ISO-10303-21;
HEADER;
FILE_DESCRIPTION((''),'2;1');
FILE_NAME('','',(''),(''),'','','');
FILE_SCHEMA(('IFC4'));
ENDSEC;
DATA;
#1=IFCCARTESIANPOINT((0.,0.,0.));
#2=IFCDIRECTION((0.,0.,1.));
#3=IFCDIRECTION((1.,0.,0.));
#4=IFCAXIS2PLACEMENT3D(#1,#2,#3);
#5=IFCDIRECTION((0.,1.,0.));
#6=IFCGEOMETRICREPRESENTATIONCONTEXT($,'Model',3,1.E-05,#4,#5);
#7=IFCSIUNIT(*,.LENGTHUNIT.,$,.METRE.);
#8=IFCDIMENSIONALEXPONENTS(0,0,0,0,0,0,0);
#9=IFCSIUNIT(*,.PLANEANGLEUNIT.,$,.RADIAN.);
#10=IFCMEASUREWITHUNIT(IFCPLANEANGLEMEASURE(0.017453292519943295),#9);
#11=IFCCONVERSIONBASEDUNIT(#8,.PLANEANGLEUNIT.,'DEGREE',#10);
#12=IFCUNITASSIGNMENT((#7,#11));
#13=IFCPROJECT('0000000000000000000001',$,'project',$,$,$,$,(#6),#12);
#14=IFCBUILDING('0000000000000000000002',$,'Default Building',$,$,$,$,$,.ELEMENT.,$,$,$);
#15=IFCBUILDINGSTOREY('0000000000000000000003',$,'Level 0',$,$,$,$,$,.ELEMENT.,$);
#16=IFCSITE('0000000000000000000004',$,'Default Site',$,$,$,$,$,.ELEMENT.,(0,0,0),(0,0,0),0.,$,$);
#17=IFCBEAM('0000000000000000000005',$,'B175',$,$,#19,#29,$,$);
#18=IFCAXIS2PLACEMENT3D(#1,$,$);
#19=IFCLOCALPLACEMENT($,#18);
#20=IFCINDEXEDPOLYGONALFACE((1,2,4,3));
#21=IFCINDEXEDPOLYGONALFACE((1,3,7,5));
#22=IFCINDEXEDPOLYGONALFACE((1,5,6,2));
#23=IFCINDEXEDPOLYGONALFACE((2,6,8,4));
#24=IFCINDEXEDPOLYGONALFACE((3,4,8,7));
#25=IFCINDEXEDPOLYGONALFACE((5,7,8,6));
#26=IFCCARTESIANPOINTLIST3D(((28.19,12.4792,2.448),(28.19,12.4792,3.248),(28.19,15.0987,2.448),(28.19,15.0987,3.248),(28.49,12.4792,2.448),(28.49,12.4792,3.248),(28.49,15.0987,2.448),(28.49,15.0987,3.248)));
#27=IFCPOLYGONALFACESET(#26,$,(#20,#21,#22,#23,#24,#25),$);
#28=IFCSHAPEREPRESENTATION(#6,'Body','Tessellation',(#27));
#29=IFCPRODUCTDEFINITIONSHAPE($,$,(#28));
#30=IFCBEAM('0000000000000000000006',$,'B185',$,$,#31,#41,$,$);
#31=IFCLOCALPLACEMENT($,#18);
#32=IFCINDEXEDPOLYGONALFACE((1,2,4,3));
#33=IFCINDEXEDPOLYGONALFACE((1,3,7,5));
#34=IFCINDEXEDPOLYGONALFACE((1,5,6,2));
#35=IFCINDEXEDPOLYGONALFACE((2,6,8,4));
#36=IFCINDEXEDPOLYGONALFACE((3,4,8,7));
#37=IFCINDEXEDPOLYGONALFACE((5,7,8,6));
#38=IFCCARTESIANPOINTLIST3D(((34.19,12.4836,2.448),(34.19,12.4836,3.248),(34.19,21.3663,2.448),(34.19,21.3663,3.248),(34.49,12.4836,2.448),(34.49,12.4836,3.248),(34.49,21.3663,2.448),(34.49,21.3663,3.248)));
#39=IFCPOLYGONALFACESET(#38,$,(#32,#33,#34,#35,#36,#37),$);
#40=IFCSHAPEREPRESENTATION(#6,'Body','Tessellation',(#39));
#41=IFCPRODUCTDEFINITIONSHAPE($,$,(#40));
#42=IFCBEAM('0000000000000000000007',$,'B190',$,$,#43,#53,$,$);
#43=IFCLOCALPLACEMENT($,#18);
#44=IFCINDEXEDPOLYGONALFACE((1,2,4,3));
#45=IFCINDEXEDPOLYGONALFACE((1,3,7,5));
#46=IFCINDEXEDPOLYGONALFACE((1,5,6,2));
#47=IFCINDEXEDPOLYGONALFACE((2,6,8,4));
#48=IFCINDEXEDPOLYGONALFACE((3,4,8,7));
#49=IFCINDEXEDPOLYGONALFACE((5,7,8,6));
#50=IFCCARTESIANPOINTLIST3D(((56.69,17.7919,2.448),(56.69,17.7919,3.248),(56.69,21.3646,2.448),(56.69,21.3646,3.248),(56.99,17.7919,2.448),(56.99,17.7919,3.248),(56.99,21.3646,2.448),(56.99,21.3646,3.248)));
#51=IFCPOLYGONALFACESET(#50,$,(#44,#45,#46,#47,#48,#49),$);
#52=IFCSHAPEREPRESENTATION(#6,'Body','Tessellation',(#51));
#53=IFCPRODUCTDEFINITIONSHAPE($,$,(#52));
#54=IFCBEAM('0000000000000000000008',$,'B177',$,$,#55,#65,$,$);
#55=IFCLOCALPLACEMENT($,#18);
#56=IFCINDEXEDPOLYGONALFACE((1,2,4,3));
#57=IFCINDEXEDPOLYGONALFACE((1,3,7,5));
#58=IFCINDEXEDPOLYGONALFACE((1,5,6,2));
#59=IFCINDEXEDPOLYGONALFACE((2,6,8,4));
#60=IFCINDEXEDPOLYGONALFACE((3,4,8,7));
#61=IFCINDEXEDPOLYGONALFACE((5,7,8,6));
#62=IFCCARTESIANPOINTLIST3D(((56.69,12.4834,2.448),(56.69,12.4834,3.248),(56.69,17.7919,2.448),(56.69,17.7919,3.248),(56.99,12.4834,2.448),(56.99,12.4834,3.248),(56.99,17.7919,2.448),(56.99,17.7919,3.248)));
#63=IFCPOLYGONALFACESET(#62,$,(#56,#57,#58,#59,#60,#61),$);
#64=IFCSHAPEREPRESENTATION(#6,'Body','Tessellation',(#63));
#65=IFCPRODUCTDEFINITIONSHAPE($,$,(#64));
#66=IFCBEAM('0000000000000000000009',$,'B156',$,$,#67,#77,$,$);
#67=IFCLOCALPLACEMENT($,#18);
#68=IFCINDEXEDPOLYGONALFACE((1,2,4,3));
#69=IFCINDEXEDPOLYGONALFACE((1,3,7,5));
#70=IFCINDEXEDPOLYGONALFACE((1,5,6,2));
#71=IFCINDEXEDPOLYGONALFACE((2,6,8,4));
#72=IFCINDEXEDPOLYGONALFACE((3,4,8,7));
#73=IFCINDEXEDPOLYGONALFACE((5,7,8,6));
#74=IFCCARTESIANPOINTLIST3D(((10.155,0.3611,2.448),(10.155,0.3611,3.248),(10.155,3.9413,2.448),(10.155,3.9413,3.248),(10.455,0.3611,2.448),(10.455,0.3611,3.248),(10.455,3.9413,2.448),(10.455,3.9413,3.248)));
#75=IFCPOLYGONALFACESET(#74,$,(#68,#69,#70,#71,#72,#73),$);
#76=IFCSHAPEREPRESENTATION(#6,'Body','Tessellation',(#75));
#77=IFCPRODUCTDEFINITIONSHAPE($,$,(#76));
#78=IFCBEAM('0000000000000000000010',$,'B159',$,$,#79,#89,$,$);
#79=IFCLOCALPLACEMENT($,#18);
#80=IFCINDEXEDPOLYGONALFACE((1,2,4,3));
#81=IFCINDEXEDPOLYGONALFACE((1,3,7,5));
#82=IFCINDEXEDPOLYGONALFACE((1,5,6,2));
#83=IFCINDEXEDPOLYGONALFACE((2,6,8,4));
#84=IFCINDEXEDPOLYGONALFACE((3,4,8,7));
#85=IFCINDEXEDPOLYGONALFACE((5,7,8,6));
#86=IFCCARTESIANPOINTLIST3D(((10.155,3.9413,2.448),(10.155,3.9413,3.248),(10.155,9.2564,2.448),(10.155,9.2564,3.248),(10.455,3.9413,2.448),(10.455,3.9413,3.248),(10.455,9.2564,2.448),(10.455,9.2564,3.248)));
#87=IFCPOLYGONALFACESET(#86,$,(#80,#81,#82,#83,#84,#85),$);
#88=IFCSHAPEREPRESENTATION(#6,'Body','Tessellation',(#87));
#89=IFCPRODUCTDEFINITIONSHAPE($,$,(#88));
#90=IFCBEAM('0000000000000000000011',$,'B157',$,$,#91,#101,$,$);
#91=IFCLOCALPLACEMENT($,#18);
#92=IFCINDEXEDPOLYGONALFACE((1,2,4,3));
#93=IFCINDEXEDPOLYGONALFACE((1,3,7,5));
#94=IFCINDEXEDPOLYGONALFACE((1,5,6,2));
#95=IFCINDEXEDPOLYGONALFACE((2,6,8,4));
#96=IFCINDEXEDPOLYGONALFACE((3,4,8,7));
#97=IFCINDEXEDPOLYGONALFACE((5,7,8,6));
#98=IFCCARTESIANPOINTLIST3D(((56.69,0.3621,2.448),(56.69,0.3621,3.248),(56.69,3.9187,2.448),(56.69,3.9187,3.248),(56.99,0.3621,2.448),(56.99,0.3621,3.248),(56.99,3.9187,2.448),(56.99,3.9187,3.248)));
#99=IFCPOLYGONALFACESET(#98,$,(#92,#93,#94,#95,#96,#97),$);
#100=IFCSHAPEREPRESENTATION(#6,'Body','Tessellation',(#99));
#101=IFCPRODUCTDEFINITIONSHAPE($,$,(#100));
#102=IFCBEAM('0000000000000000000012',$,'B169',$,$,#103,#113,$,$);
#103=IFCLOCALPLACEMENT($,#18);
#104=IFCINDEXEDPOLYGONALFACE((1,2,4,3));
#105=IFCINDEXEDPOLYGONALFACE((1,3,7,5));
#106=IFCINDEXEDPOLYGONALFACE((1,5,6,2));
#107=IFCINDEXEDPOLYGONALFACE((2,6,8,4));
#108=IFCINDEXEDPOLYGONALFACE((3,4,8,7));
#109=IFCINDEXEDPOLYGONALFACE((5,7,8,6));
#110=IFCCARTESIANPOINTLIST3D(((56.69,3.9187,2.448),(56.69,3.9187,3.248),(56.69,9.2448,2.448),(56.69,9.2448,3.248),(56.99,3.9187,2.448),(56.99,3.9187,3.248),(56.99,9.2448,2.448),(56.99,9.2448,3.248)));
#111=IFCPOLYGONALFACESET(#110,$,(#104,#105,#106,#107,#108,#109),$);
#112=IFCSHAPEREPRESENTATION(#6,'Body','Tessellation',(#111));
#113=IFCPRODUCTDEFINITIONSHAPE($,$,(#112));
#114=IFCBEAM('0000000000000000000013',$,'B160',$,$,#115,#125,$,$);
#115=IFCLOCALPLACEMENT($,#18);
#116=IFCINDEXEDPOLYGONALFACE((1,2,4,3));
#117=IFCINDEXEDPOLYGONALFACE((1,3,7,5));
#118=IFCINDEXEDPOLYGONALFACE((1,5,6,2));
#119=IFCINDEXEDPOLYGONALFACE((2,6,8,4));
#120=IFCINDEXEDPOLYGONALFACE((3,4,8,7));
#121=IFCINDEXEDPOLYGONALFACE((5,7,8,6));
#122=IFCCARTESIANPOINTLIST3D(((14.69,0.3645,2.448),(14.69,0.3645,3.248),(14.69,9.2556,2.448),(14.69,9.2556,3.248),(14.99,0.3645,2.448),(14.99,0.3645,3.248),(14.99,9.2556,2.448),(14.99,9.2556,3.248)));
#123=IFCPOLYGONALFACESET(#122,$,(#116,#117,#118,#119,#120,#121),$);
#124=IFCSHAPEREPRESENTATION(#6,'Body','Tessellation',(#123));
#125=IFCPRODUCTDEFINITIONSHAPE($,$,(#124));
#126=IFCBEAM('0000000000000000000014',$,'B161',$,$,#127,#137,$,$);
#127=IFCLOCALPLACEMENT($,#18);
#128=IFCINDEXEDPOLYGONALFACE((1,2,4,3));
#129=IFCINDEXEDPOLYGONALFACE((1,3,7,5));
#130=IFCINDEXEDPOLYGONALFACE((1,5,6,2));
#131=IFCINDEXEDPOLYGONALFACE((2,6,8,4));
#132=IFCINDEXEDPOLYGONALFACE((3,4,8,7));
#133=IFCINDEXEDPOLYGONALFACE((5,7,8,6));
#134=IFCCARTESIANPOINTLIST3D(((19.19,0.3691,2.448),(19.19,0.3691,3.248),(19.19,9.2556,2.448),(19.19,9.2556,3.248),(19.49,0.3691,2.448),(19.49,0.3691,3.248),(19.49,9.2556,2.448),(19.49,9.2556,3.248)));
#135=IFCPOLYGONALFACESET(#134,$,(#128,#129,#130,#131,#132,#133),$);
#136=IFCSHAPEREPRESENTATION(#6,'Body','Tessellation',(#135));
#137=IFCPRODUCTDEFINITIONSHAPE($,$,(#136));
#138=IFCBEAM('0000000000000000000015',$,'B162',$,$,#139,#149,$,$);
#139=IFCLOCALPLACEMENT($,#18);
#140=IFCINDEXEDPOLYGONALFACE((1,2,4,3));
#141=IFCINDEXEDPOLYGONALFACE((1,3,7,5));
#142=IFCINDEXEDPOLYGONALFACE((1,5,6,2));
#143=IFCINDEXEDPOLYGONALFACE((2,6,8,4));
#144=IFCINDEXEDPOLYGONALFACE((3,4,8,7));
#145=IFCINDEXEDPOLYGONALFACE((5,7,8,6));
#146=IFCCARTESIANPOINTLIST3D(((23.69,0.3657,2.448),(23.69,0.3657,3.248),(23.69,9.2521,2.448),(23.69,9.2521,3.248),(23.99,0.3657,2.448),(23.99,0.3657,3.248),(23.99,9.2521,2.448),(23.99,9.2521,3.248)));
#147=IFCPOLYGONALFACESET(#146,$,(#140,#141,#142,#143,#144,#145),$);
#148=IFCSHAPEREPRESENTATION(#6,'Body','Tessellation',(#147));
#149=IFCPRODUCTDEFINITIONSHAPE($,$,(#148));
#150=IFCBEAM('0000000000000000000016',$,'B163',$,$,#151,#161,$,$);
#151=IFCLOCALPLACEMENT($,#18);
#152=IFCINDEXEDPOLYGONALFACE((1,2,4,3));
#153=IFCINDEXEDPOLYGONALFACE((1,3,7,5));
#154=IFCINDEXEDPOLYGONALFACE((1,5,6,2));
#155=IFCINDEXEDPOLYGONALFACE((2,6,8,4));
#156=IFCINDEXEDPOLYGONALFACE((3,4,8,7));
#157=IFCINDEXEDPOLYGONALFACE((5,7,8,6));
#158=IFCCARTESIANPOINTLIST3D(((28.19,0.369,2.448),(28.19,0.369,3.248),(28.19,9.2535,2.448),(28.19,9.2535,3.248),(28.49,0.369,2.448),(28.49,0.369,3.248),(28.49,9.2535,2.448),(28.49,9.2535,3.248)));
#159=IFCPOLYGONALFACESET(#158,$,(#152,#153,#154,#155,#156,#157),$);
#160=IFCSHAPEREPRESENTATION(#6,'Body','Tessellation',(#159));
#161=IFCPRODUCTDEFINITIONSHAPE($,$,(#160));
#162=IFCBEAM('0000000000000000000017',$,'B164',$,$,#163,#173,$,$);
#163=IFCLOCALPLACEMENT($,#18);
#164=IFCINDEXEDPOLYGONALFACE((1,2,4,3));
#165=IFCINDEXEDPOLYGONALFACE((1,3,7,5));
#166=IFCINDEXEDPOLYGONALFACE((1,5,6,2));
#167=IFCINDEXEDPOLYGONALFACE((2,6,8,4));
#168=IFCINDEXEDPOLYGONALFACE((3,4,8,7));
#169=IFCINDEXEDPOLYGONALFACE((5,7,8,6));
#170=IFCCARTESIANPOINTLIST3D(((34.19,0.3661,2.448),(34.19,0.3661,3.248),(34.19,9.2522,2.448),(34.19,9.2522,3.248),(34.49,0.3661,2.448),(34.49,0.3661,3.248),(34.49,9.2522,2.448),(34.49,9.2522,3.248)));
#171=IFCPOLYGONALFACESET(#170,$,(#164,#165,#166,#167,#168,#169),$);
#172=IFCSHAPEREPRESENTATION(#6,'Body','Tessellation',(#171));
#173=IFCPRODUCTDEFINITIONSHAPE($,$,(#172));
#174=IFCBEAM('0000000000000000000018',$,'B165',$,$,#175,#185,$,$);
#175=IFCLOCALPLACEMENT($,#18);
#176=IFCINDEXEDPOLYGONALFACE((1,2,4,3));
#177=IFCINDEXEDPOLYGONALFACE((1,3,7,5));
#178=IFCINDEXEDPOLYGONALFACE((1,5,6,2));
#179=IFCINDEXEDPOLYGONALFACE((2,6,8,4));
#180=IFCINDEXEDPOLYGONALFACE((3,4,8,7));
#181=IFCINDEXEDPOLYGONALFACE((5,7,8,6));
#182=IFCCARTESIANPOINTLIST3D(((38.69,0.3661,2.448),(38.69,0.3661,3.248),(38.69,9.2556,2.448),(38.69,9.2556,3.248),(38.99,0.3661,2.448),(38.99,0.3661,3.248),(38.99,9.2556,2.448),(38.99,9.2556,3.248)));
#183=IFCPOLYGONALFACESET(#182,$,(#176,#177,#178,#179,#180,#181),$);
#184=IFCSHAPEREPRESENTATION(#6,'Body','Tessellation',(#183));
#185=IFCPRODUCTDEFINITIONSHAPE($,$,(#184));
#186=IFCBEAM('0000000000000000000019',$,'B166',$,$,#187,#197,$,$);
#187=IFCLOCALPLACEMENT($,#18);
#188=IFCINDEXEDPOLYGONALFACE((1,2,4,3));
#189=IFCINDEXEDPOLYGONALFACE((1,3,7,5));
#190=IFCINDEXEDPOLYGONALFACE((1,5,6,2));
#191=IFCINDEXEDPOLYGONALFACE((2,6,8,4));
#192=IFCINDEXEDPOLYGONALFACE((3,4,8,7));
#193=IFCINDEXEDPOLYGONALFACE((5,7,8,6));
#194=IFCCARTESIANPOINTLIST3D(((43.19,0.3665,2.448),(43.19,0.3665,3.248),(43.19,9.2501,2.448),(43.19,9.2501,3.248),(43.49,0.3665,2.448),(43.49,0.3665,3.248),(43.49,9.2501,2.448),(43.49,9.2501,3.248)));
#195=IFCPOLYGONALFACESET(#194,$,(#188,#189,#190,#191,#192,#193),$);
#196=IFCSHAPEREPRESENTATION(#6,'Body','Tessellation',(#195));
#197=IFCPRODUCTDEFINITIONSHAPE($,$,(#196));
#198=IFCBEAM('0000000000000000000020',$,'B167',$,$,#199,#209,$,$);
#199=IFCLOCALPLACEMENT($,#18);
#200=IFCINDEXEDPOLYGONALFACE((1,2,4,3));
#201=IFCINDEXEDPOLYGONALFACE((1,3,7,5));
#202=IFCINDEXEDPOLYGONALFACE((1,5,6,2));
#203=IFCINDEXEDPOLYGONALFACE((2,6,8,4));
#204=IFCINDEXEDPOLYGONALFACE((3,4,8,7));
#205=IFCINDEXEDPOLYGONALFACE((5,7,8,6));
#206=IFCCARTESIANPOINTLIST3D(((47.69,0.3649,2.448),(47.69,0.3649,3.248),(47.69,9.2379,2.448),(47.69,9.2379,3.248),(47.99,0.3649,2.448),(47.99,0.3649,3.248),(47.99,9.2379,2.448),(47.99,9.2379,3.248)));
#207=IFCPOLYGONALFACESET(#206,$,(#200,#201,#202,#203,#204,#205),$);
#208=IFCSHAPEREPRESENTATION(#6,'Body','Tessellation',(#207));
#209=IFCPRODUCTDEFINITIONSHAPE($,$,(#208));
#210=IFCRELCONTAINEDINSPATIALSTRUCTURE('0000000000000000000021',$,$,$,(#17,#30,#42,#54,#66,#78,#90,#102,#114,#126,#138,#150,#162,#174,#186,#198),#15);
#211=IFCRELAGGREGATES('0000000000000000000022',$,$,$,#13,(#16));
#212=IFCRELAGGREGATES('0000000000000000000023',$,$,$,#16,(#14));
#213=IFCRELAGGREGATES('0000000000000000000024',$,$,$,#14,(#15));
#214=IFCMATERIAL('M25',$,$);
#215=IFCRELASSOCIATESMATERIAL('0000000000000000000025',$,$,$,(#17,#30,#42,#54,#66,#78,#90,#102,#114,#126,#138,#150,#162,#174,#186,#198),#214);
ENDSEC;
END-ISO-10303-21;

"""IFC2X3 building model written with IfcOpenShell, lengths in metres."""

from ifc_helpers import new_model, entity, si_unit, converted_unit, direction, frame, frame_2d, origin_with_axes, place, context, project, spatial, rectangle, extrude, material, element, save


model = new_model("IFC2X3")

# Units and contexts
model_context = context("Model", 3, precision=1e-05, world=origin_with_axes(), true_north=direction((0.0, 1.0, 0.0)))
ifc_project = project(units=[si_unit("LENGTHUNIT", "METRE"), converted_unit("PLANEANGLEUNIT", "DEGREE", entity("IfcPlaneAngleMeasure", 0.017453292519943295), si_unit("PLANEANGLEUNIT", "RADIAN"), dimensions=[0, 0, 0, 0, 0, 0, 0])], contexts=[model_context])

# Site, building, storey
site = spatial("IfcSite", under=ifc_project, Name="Default Site", CompositionType="ELEMENT", RefLatitude=(0, 0, 0), RefLongitude=(0, 0, 0), RefElevation=0.0)
building = spatial("IfcBuilding", under=site, Name="Default Building", CompositionType="ELEMENT")
storey = spatial("IfcBuildingStorey", under=building, Name="Level 0", CompositionType="ELEMENT")

# Beams
ifc_material = material(Name="M25")
placement = place(None, origin_with_axes())
element("IfcBeam", 1, at=placement, inside=storey, material=ifc_material, Name="B175", context=model_context, shape_type="SweptSolid", body=[
    extrude(rectangle(XDim=0.3, YDim=0.8, at=frame_2d((0.0, 0.0), x_axis=(0.0, 1.0, 0.0))), frame((28.34, 15.0987, 2.848), z_axis=(0.0, -1.0, 0.0), x_axis=(0.0, 0.0, -1.0)), (0.0, 0.0, 1.0), 2.6195),
])
element("IfcBeam", 2, at=placement, inside=storey, material=ifc_material, Name="B185", context=model_context, shape_type="SweptSolid", body=[
    extrude(rectangle(XDim=0.3, YDim=0.8, at=frame_2d((0.0, 0.0), x_axis=(0.0, 1.0, 0.0))), frame((34.34, 12.4836, 2.848), z_axis=(0.0, 1.0, 0.0), x_axis=(0.0, 0.0, -1.0)), (0.0, 0.0, 1.0), 8.8827),
])
element("IfcBeam", 3, at=placement, inside=storey, material=ifc_material, Name="B190", context=model_context, shape_type="SweptSolid", body=[
    extrude(rectangle(XDim=0.3, YDim=0.8, at=frame_2d((0.0, 0.0), x_axis=(0.0, 1.0, 0.0))), frame((56.84, 17.7919, 2.848), z_axis=(0.0, 1.0, 0.0), x_axis=(0.0, 0.0, -1.0)), (0.0, 0.0, 1.0), 3.5727),
])
element("IfcBeam", 4, at=placement, inside=storey, material=ifc_material, Name="B177", context=model_context, shape_type="SweptSolid", body=[
    extrude(rectangle(XDim=0.3, YDim=0.8, at=frame_2d((0.0, 0.0), x_axis=(0.0, 1.0, 0.0))), frame((56.84, 12.4834, 2.848), z_axis=(0.0, 1.0, 0.0), x_axis=(0.0, 0.0, -1.0)), (0.0, 0.0, 1.0), 5.3085),
])
element("IfcBeam", 5, at=placement, inside=storey, material=ifc_material, Name="B156", context=model_context, shape_type="SweptSolid", body=[
    extrude(rectangle(XDim=0.3, YDim=0.8, at=frame_2d((0.0, 0.0), x_axis=(0.0, 1.0, 0.0))), frame((10.305, 3.9413, 2.848), z_axis=(0.0, -1.0, 0.0), x_axis=(0.0, 0.0, -1.0)), (0.0, 0.0, 1.0), 3.5802),
])
element("IfcBeam", 6, at=placement, inside=storey, material=ifc_material, Name="B159", context=model_context, shape_type="SweptSolid", body=[
    extrude(rectangle(XDim=0.3, YDim=0.8, at=frame_2d((0.0, 0.0), x_axis=(0.0, 1.0, 0.0))), frame((10.305, 3.9413, 2.848), z_axis=(0.0, 1.0, 0.0), x_axis=(0.0, 0.0, -1.0)), (0.0, 0.0, 1.0), 5.3151),
])
element("IfcBeam", 7, at=placement, inside=storey, material=ifc_material, Name="B157", context=model_context, shape_type="SweptSolid", body=[
    extrude(rectangle(XDim=0.3, YDim=0.8, at=frame_2d((0.0, 0.0), x_axis=(0.0, 1.0, 0.0))), frame((56.84, 0.3621, 2.848), z_axis=(0.0, 1.0, 0.0), x_axis=(0.0, 0.0, -1.0)), (0.0, 0.0, 1.0), 3.5566),
])
element("IfcBeam", 8, at=placement, inside=storey, material=ifc_material, Name="B169", context=model_context, shape_type="SweptSolid", body=[
    extrude(rectangle(XDim=0.3, YDim=0.8, at=frame_2d((0.0, 0.0), x_axis=(0.0, 1.0, 0.0))), frame((56.84, 3.9187, 2.848), z_axis=(0.0, 1.0, 0.0), x_axis=(0.0, 0.0, -1.0)), (0.0, 0.0, 1.0), 5.3261),
])
element("IfcBeam", 9, at=placement, inside=storey, material=ifc_material, Name="B160", context=model_context, shape_type="SweptSolid", body=[
    extrude(rectangle(XDim=0.3, YDim=0.8, at=frame_2d((0.0, 0.0), x_axis=(0.0, 1.0, 0.0))), frame((14.84, 0.3645, 2.848), z_axis=(0.0, 1.0, 0.0), x_axis=(0.0, 0.0, -1.0)), (0.0, 0.0, 1.0), 8.891),
])
element("IfcBeam", 10, at=placement, inside=storey, material=ifc_material, Name="B161", context=model_context, shape_type="SweptSolid", body=[
    extrude(rectangle(XDim=0.3, YDim=0.8, at=frame_2d((0.0, 0.0), x_axis=(0.0, 1.0, 0.0))), frame((19.34, 0.3691, 2.848), z_axis=(0.0, 1.0, 0.0), x_axis=(0.0, 0.0, -1.0)), (0.0, 0.0, 1.0), 8.8865),
])
element("IfcBeam", 11, at=placement, inside=storey, material=ifc_material, Name="B162", context=model_context, shape_type="SweptSolid", body=[
    extrude(rectangle(XDim=0.3, YDim=0.8, at=frame_2d((0.0, 0.0), x_axis=(0.0, 1.0, 0.0))), frame((23.84, 0.3657, 2.848), z_axis=(0.0, 1.0, 0.0), x_axis=(0.0, 0.0, -1.0)), (0.0, 0.0, 1.0), 8.8864),
])
element("IfcBeam", 12, at=placement, inside=storey, material=ifc_material, Name="B163", context=model_context, shape_type="SweptSolid", body=[
    extrude(rectangle(XDim=0.3, YDim=0.8, at=frame_2d((0.0, 0.0), x_axis=(0.0, 1.0, 0.0))), frame((28.34, 0.369, 2.848), z_axis=(0.0, 1.0, 0.0), x_axis=(0.0, 0.0, -1.0)), (0.0, 0.0, 1.0), 8.8845),
])
element("IfcBeam", 13, at=placement, inside=storey, material=ifc_material, Name="B164", context=model_context, shape_type="SweptSolid", body=[
    extrude(rectangle(XDim=0.3, YDim=0.8, at=frame_2d((0.0, 0.0), x_axis=(0.0, 1.0, 0.0))), frame((34.34, 0.3661, 2.848), z_axis=(0.0, 1.0, 0.0), x_axis=(0.0, 0.0, -1.0)), (0.0, 0.0, 1.0), 8.8861),
])
element("IfcBeam", 14, at=placement, inside=storey, material=ifc_material, Name="B165", context=model_context, shape_type="SweptSolid", body=[
    extrude(rectangle(XDim=0.3, YDim=0.8, at=frame_2d((0.0, 0.0), x_axis=(0.0, 1.0, 0.0))), frame((38.84, 0.3661, 2.848), z_axis=(0.0, 1.0, 0.0), x_axis=(0.0, 0.0, -1.0)), (0.0, 0.0, 1.0), 8.8895),
])
element("IfcBeam", 15, at=placement, inside=storey, material=ifc_material, Name="B166", context=model_context, shape_type="SweptSolid", body=[
    extrude(rectangle(XDim=0.3, YDim=0.8, at=frame_2d((0.0, 0.0), x_axis=(0.0, 1.0, 0.0))), frame((43.34, 0.3665, 2.848), z_axis=(0.0, 1.0, 0.0), x_axis=(0.0, 0.0, -1.0)), (0.0, 0.0, 1.0), 8.8836),
])
element("IfcBeam", 16, at=placement, inside=storey, material=ifc_material, Name="B167", context=model_context, shape_type="SweptSolid", body=[
    extrude(rectangle(XDim=0.3, YDim=0.8, at=frame_2d((0.0, 0.0), x_axis=(0.0, 1.0, 0.0))), frame((47.84, 0.3649, 2.848), z_axis=(0.0, 1.0, 0.0), x_axis=(0.0, 0.0, -1.0)), (0.0, 0.0, 1.0), 8.873),
])

save(model, "model.ifc")
